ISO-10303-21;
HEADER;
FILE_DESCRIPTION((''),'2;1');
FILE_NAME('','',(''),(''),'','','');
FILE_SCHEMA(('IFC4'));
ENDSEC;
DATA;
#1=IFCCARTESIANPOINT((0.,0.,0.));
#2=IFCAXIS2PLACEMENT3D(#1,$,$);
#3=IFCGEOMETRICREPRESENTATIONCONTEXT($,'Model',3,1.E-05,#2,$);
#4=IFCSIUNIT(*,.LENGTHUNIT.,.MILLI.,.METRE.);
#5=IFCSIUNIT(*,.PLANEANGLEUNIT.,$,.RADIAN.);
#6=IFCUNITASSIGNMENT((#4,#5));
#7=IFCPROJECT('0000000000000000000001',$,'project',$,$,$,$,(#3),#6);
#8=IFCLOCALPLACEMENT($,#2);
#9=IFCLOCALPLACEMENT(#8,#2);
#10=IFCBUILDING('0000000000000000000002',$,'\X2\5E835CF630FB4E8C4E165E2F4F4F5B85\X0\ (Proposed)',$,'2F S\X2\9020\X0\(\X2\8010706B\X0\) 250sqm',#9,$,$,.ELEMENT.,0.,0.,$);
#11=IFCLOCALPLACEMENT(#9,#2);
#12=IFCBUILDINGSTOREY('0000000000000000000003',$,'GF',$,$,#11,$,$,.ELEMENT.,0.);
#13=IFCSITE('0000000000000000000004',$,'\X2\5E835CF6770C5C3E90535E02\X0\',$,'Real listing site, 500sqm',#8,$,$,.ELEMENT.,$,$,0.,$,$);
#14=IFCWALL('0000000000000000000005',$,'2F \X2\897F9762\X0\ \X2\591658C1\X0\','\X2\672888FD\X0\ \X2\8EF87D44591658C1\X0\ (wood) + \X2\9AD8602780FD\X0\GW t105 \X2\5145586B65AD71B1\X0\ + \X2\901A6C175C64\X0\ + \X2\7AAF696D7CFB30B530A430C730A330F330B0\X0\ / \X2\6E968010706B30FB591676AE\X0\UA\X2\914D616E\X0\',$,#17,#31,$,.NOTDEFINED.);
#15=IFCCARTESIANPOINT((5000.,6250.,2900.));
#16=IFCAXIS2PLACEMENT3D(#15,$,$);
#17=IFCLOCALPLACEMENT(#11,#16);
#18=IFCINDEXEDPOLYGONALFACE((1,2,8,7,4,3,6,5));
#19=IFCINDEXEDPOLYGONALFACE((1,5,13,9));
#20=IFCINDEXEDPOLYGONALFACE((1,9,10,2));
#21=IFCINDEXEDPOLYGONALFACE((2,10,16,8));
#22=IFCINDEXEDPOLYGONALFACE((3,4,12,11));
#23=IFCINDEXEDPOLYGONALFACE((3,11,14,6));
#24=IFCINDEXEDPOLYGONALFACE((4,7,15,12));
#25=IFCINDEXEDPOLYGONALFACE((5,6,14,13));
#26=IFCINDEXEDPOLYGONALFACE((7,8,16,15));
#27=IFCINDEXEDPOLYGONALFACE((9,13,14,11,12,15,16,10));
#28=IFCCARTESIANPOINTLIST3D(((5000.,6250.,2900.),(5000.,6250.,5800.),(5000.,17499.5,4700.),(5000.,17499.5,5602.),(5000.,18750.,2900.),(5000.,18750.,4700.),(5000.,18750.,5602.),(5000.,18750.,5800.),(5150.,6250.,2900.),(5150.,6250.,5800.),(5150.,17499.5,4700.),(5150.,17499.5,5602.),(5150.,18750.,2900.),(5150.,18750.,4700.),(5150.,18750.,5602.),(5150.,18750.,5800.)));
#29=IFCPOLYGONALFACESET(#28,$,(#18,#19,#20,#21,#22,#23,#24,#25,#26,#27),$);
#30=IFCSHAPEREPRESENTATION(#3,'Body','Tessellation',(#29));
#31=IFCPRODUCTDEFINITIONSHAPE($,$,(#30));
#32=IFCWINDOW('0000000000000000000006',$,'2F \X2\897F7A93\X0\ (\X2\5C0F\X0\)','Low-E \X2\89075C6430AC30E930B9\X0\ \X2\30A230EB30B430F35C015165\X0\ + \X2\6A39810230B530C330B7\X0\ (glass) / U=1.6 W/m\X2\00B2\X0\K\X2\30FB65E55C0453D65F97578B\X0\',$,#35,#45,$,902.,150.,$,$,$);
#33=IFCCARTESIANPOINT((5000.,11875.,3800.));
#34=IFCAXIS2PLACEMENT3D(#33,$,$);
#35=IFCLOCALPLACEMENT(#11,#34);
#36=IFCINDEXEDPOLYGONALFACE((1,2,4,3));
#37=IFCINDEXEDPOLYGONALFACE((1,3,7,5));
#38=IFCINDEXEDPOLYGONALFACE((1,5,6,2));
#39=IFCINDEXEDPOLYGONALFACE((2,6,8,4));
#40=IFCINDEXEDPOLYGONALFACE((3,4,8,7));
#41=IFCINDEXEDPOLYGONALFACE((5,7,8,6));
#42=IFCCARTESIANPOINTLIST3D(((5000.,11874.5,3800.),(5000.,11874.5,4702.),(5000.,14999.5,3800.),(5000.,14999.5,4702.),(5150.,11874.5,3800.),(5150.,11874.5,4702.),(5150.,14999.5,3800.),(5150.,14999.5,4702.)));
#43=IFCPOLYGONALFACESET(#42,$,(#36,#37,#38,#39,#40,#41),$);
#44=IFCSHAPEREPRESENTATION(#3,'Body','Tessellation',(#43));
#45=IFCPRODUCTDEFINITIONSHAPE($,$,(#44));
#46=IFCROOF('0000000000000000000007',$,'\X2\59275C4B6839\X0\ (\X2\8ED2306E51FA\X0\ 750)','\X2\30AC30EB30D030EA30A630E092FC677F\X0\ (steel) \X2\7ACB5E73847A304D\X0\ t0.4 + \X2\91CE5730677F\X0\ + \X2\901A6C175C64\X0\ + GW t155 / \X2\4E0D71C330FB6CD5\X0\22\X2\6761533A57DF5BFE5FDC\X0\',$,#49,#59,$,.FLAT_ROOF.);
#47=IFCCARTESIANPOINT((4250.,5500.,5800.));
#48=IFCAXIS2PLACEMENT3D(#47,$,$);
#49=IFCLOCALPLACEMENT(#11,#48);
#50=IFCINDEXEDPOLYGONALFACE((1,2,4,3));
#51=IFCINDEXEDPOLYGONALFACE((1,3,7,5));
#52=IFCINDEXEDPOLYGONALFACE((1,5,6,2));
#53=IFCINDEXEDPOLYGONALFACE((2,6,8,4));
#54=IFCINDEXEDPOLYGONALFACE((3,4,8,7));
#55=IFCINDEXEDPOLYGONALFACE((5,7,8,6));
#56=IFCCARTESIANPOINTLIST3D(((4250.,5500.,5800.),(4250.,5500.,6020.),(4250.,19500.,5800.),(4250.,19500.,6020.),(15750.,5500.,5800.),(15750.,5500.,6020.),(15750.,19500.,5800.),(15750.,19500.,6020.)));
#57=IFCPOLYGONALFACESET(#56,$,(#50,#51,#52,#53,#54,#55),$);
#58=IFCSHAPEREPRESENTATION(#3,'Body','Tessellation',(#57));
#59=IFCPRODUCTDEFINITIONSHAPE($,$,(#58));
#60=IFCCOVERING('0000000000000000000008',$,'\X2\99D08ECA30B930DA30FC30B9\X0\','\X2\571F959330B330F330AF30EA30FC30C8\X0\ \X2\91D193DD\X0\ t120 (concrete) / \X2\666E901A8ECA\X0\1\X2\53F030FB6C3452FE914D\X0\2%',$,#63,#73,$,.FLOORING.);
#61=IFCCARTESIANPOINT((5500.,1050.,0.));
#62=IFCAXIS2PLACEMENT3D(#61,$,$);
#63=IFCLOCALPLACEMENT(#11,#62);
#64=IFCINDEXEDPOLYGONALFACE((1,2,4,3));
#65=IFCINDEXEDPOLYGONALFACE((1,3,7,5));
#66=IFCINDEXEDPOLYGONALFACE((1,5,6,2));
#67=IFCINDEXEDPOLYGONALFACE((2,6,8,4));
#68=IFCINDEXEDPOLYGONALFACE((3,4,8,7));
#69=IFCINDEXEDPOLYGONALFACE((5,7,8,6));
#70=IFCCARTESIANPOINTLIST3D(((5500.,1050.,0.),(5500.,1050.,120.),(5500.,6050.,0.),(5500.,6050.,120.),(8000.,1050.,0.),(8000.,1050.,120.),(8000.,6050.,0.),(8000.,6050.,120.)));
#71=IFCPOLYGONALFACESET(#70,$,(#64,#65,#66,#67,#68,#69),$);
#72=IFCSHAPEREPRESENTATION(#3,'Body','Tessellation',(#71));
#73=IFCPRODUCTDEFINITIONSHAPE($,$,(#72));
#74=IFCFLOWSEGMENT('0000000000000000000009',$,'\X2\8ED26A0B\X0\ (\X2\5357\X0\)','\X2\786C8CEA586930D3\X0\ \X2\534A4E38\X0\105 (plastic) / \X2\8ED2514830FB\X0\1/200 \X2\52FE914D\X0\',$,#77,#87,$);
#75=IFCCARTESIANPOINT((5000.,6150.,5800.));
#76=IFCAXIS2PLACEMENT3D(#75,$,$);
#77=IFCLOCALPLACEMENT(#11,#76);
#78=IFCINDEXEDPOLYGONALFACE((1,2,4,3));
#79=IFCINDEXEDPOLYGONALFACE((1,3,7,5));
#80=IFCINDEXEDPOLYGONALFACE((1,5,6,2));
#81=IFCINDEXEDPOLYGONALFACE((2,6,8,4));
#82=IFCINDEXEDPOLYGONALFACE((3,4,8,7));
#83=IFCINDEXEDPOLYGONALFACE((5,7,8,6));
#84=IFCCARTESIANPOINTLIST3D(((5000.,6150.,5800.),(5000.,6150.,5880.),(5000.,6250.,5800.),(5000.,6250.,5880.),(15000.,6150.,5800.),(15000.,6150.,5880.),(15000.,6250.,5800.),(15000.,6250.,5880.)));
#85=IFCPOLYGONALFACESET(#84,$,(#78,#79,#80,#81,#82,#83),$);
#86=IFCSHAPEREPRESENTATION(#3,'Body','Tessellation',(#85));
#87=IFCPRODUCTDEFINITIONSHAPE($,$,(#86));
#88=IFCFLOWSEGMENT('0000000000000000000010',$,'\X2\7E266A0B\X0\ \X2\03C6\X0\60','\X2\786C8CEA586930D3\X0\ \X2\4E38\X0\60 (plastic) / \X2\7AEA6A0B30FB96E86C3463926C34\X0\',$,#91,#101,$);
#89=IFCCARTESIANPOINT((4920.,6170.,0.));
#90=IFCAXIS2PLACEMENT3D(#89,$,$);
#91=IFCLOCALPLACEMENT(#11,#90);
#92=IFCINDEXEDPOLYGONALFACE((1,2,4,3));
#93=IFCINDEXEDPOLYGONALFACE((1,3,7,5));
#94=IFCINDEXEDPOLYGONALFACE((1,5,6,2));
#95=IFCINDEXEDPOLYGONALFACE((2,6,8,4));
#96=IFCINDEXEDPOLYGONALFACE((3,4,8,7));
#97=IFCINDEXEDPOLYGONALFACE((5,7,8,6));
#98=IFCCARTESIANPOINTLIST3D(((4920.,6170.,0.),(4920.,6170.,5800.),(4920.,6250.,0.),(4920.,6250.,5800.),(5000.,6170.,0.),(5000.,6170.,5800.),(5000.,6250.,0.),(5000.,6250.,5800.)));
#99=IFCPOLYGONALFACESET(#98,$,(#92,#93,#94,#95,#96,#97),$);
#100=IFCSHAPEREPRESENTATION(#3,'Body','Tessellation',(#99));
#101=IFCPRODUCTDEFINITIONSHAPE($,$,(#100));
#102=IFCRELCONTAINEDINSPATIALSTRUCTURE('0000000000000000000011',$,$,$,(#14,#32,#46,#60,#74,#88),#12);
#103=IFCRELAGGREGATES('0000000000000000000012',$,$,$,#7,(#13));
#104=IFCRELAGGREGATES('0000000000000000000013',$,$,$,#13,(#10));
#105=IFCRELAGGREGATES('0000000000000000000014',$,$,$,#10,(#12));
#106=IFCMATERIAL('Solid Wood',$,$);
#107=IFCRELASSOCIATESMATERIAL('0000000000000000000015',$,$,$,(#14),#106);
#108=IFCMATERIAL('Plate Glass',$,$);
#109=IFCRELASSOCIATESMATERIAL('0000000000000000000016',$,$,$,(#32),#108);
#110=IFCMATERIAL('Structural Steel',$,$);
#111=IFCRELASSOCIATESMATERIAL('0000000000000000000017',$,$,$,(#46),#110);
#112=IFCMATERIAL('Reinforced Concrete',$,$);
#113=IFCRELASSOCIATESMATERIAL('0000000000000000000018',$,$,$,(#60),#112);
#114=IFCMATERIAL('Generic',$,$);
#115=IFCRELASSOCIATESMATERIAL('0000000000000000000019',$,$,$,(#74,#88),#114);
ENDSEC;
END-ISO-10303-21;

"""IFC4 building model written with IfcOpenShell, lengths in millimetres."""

from ifc_helpers import new_model, si_unit, frame, frame_2d, origin, place, context, project, spatial, rectangle, extrude, material, element, fill, save


model = new_model("IFC4")

# Units and contexts
model_context = context("Model", 3, precision=1e-05, world=origin())
ifc_project = project(units=[si_unit("LENGTHUNIT", "METRE", prefix="MILLI"), si_unit("PLANEANGLEUNIT", "RADIAN")], contexts=[model_context])

# Site, building, storey
site_placement = place(None, origin())
site = spatial("IfcSite", under=ifc_project, at=site_placement, Name="広島県尾道市", ObjectType="Real listing site, 500sqm", CompositionType="ELEMENT", RefElevation=0.0)
building_placement = place(site_placement, origin())
building = spatial("IfcBuilding", under=site, at=building_placement, Name="広島・二世帯住宅 (Proposed)", ObjectType="2F S造(耐火) 250sqm", CompositionType="ELEMENT", ElevationOfRefHeight=0.0, ElevationOfTerrain=0.0)
storey_placement = place(building_placement, origin())
storey = spatial("IfcBuildingStorey", under=building, at=storey_placement, Name="GF", CompositionType="ELEMENT", Elevation=0.0)

# Shared definitions
ifc_material_1 = material(Name="Solid Wood")

# Shared definitions
ifc_material_2 = material(Name="Reinforced Concrete")

# Shared definitions
ifc_material_3 = material(Name="Plate Glass")

# Wall, opening, window
wall_1_placement = place(storey_placement, frame((5000.0, 6250.0, 2900.0)))
wall_1 = element("IfcWall", 1, at=wall_1_placement, inside=storey, material=ifc_material_1, Name="2F 西面 外壁", Description="木製 軸組外壁 (wood) + 高性能GW t105 充填断熱 + 通気層 + 窯業系サイディング / 準耐火・外皮UA配慮", PredefinedType="NOTDEFINED", context=model_context, shape_type="SweptSolid", body=[
    extrude(rectangle(XDim=150.0, YDim=12500.0, at=frame_2d((75.0, 6250.0))), frame((5000.0, 6250.0, 2900.0)), (0.0, 0.0, 1.0), 2900.0),
])
opening_1_placement = place(storey_placement, frame((5000.0, 11875.0, 3800.0)))
opening_1 = element("IfcOpeningElement", 2, at=opening_1_placement, cuts=wall_1, PredefinedType="NOTDEFINED", context=model_context, shape_type="SweptSolid", body=[
    extrude(rectangle(XDim=150.0, YDim=3125.0, at=frame_2d((75.0, 1562.0))), frame((5000.0, 11875.0, 3800.0)), (0.0, 0.0, 1.0), 902.0),
])
window_1_placement = place(storey_placement, frame((5000.0, 11875.0, 3800.0)))
window_1 = element("IfcWindow", 3, at=window_1_placement, inside=storey, material=ifc_material_3, Name="2F 西窓 (小)", Description="Low-E 複層ガラス アルゴン封入 + 樹脂サッシ (glass) / U=1.6 W/m²K・日射取得型", OverallHeight=902.0, OverallWidth=150.0, context=model_context, shape_type="SweptSolid", body=[
    extrude(rectangle(XDim=150.0, YDim=3125.0, at=frame_2d((75.0, 1562.0))), frame((5000.0, 11875.0, 3800.0)), (0.0, 0.0, 1.0), 902.0),
])
fill(opening_1, window_1)

# Roof
ifc_material_4 = material(Name="Structural Steel")
roof_placement = place(storey_placement, frame((4250.0, 5500.0, 5800.0)))
element("IfcRoof", 4, at=roof_placement, inside=storey, material=ifc_material_4, Name="大屋根 (軒の出 750)", Description="ガルバリウム鋼板 (steel) 立平葺き t0.4 + 野地板 + 通気層 + GW t155 / 不燃・法22条区域対応", PredefinedType="FLAT_ROOF", context=model_context, shape_type="SweptSolid", body=[
    extrude(rectangle(XDim=11500.0, YDim=14000.0, at=frame_2d((5750.0, 7000.0))), frame((4250.0, 5500.0, 5800.0)), (0.0, 0.0, 1.0), 220.0),
])

# Covering
covering_placement = place(storey_placement, frame((5500.0, 1050.0, 0.0)))
element("IfcCovering", 5, at=covering_placement, inside=storey, material=ifc_material_2, Name="駐車スペース", Description="土間コンクリート 金鏝 t120 (concrete) / 普通車1台・水勾配2%", PredefinedType="FLOORING", context=model_context, shape_type="SweptSolid", body=[
    extrude(rectangle(XDim=2500.0, YDim=5000.0, at=frame_2d((1250.0, 2500.0))), frame((5500.0, 1050.0, 0.0)), (0.0, 0.0, 1.0), 120.0),
])

# Flow segments
ifc_material_5 = material(Name="Generic")
flow_segment_1_placement = place(storey_placement, frame((5000.0, 6150.0, 5800.0)))
element("IfcFlowSegment", 6, at=flow_segment_1_placement, inside=storey, material=ifc_material_5, Name="軒樋 (南)", Description="硬質塩ビ 半丸105 (plastic) / 軒先・1/200 勾配", context=model_context, shape_type="SweptSolid", body=[
    extrude(rectangle(XDim=10000.0, YDim=100.0, at=frame_2d((5000.0, 50.0))), frame((5000.0, 6150.0, 5800.0)), (0.0, 0.0, 1.0), 80.0),
])
flow_segment_2_placement = place(storey_placement, frame((4920.0, 6170.0, 0.0)))
element("IfcFlowSegment", 7, at=flow_segment_2_placement, inside=storey, material=ifc_material_5, Name="縦樋 φ60", Description="硬質塩ビ 丸60 (plastic) / 竪樋・雨水排水", context=model_context, shape_type="SweptSolid", body=[
    extrude(rectangle(XDim=80.0, YDim=80.0, at=frame_2d((40.0, 40.0))), frame((4920.0, 6170.0, 0.0)), (0.0, 0.0, 1.0), 5800.0),
])

save(model, "model.ifc")
